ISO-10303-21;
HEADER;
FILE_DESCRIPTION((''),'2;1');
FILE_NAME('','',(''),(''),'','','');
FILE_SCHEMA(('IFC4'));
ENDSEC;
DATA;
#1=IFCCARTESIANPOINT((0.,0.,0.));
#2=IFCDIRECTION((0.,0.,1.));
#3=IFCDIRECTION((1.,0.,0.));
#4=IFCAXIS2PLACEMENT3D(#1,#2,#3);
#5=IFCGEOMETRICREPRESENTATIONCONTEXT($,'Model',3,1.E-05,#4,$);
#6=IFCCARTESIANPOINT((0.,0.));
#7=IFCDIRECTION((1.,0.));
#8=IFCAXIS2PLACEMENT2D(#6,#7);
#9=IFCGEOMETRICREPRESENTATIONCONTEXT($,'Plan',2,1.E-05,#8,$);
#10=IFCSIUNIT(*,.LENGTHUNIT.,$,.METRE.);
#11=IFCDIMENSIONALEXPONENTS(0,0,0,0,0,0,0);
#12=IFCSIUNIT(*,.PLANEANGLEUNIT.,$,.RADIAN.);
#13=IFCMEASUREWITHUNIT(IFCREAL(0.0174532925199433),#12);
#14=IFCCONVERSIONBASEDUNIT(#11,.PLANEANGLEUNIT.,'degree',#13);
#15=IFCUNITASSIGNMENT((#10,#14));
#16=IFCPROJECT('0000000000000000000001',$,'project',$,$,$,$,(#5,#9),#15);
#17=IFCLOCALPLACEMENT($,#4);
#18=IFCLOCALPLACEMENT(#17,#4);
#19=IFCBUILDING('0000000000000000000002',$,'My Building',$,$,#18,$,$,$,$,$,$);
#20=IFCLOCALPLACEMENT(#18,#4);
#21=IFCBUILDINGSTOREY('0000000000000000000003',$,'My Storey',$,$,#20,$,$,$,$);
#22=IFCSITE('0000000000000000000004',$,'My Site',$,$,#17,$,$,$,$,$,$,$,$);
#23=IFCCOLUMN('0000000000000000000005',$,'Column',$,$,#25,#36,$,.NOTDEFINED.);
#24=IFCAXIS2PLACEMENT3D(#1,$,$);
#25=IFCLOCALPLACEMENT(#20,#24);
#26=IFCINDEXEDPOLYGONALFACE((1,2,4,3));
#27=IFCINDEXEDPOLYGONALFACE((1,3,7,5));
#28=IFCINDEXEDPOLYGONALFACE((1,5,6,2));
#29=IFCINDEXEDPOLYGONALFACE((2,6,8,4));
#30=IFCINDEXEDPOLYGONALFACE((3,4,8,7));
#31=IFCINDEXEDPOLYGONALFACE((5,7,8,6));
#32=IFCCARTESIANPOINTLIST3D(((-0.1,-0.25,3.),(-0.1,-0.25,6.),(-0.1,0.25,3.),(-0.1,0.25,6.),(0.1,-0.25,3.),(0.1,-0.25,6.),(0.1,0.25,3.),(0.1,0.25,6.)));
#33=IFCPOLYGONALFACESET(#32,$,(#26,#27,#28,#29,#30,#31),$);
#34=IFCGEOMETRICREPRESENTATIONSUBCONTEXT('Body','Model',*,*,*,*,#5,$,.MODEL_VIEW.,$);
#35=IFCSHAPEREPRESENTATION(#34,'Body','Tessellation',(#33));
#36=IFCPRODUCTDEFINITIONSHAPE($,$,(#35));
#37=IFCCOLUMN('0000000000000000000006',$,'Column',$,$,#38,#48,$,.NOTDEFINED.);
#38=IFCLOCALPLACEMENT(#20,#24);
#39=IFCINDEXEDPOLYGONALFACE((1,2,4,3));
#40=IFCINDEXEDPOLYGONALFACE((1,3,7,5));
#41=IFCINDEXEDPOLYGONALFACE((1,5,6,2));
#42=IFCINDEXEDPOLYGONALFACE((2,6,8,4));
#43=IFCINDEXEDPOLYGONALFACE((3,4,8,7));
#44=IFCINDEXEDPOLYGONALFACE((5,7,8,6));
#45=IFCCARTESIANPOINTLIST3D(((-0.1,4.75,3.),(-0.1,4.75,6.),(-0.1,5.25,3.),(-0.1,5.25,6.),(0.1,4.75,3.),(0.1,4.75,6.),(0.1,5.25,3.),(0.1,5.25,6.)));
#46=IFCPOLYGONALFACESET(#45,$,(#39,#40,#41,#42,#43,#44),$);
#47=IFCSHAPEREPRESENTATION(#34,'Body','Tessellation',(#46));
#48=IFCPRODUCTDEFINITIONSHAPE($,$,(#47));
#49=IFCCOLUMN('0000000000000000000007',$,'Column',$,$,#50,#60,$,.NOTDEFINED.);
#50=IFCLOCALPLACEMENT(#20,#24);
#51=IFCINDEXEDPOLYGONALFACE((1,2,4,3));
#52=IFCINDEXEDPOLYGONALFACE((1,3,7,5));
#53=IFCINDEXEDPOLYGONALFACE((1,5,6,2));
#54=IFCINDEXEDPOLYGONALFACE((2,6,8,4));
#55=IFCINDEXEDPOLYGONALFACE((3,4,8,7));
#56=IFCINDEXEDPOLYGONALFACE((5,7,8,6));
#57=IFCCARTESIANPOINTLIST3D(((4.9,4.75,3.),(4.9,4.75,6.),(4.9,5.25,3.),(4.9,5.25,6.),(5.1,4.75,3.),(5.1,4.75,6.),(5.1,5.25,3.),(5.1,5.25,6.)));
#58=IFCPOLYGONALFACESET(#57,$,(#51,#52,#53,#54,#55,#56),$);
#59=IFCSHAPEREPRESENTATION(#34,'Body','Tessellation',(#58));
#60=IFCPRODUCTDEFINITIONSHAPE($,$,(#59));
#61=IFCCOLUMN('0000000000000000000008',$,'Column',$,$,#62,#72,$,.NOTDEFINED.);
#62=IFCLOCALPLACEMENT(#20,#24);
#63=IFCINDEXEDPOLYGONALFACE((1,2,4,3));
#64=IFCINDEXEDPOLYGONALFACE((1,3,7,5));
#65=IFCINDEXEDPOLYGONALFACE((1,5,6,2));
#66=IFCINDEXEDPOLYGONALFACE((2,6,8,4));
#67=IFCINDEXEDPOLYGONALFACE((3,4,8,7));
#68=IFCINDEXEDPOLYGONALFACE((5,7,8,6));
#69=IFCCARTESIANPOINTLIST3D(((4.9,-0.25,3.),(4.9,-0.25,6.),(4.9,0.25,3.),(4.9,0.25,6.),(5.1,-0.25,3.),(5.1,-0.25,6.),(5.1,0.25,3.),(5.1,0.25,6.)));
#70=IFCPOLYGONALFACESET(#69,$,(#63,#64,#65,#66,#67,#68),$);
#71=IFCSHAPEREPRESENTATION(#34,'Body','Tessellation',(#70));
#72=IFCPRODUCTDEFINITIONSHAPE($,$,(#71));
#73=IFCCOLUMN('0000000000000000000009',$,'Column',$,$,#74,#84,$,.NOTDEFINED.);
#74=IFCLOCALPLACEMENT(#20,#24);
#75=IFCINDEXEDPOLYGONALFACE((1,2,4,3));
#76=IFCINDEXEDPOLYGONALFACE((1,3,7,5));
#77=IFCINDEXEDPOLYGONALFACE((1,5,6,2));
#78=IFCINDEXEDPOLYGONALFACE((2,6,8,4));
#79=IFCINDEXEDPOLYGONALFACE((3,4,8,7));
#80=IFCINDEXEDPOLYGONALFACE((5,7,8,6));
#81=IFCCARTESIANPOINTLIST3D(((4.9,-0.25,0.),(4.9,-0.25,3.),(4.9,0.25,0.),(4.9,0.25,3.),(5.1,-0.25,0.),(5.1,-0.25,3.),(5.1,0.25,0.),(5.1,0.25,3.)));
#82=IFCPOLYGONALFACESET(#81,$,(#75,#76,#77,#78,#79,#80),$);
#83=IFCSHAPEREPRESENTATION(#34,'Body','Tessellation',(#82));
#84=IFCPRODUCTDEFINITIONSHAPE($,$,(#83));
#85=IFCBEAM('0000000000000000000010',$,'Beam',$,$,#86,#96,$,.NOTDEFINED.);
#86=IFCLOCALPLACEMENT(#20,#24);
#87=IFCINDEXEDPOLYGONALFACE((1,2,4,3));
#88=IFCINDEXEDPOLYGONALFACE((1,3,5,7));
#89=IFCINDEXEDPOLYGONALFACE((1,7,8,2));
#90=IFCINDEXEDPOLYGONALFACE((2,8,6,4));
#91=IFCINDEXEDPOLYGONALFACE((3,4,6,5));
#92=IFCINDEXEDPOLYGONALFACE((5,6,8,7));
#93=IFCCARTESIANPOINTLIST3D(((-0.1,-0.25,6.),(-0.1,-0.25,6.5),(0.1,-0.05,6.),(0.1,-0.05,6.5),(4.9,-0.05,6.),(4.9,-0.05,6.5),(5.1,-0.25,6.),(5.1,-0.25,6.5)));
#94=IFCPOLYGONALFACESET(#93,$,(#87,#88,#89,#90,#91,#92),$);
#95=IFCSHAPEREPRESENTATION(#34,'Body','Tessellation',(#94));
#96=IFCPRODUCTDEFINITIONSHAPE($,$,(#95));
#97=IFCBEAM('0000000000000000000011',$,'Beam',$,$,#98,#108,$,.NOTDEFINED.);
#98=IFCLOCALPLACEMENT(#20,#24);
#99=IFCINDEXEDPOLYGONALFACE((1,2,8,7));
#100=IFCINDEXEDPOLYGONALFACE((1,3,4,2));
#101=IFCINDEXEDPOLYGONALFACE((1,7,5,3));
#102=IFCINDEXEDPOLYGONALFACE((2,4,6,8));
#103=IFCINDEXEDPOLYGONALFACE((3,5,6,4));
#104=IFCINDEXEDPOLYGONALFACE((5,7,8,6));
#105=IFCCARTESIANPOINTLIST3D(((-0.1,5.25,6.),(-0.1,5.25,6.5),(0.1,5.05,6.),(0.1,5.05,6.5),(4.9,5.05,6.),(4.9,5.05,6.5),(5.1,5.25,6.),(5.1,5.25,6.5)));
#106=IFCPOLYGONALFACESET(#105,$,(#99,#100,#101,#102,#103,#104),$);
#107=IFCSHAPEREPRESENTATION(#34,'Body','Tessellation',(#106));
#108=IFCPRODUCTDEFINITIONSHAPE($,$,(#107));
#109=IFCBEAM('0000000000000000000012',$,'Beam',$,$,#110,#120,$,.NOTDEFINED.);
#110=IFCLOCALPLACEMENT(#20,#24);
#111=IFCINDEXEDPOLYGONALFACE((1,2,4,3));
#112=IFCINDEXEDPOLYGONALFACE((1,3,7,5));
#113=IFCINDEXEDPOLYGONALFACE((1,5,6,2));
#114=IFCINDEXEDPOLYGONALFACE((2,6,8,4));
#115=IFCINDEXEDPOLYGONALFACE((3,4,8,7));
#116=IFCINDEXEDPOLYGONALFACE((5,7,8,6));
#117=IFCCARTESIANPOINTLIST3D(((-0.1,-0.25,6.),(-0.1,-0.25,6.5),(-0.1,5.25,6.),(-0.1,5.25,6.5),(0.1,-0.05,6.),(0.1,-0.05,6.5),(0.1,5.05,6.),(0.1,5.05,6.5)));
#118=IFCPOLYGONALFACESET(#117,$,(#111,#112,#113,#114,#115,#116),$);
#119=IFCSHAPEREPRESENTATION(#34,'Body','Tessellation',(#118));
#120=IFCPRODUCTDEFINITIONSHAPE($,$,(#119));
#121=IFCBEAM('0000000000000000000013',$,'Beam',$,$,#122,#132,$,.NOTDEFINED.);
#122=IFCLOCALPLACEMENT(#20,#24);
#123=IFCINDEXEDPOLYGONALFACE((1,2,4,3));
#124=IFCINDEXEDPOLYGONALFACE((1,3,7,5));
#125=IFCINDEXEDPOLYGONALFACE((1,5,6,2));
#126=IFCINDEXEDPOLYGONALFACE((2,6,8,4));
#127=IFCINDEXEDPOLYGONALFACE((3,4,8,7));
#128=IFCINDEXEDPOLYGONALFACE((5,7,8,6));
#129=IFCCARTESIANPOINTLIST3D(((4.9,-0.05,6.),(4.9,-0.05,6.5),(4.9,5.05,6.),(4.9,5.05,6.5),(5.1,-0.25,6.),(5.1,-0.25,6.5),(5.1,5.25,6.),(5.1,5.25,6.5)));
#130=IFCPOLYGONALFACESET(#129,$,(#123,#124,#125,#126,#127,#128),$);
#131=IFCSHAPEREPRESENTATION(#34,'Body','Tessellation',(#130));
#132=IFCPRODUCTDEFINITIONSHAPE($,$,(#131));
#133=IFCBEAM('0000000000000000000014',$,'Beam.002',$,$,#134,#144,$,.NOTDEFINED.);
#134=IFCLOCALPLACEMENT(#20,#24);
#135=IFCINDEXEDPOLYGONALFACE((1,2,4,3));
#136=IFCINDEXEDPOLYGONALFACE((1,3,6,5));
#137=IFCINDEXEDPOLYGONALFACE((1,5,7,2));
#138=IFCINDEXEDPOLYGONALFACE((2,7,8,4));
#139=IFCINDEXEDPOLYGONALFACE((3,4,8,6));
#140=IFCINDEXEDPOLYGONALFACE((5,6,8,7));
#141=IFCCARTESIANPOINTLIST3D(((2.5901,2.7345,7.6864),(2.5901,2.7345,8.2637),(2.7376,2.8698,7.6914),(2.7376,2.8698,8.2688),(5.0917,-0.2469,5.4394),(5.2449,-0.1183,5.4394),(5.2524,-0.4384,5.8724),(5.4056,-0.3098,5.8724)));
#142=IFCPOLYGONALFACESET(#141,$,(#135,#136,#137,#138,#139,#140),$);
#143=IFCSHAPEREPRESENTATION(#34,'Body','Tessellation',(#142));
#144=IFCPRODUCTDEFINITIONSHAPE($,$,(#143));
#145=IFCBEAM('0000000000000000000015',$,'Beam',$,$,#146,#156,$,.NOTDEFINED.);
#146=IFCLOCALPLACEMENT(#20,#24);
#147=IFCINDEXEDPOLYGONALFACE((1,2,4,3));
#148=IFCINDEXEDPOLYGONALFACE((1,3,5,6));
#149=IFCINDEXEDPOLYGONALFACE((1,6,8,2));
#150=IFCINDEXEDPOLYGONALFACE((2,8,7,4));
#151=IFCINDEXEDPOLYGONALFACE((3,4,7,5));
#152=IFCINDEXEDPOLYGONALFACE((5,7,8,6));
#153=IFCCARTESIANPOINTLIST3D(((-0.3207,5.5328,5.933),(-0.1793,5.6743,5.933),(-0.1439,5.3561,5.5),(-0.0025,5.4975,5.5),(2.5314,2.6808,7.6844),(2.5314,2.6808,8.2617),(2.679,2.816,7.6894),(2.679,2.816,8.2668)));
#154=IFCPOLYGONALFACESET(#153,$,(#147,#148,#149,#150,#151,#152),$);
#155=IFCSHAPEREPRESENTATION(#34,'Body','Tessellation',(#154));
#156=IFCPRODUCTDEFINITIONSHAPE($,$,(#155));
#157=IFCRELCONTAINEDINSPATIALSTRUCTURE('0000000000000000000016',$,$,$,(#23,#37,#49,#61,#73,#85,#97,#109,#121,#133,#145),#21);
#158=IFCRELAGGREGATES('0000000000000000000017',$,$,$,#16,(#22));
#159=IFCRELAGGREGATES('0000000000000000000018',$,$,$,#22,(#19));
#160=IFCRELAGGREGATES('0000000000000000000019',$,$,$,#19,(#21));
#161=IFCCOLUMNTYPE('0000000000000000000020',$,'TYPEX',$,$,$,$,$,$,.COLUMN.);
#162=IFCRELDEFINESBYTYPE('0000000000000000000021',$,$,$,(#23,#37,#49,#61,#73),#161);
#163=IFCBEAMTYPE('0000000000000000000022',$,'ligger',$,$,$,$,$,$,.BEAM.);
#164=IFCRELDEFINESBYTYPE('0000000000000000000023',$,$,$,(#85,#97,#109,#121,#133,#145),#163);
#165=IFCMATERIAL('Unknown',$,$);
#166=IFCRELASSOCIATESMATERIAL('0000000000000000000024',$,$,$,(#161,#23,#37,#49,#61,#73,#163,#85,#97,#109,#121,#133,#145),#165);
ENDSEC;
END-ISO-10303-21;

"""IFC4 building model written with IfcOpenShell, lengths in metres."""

from ifc_helpers import new_model, entity, si_unit, converted_unit, frame, origin_with_axes, origin_2d_with_axis, place, context, subcontext, project, spatial, rectangle, extrude, clip, halfspace, material, material_profile, profile_set, profile_usage, type_object, element, save


model = new_model("IFC4")

# Units and contexts
model_context = context("Model", 3, precision=1e-05, world=origin_with_axes())
plan_context = context("Plan", 2, precision=1e-05, world=origin_2d_with_axis())
body_context = subcontext(model_context, "Body", "Model", "MODEL_VIEW")
ifc_project = project(units=[si_unit("LENGTHUNIT", "METRE"), converted_unit("PLANEANGLEUNIT", "degree", entity("IfcReal", 0.0174532925199433), si_unit("PLANEANGLEUNIT", "RADIAN"), dimensions=[0, 0, 0, 0, 0, 0, 0])], contexts=[model_context, plan_context])

# Site, building, storey
site_placement = place(None, origin_with_axes())
site = spatial("IfcSite", under=ifc_project, at=site_placement, Name="My Site")
building_placement = place(site_placement, origin_with_axes())
building = spatial("IfcBuilding", under=site, at=building_placement, Name="My Building")
storey_placement = place(building_placement, origin_with_axes())
storey = spatial("IfcBuildingStorey", under=building, at=storey_placement, Name="My Storey")

# Columns
ifc_material = material(Name="Unknown")
ifc_material_profile_1 = material_profile(ifc_material, rectangle(XDim=0.2, YDim=0.5))
ifc_profile_set_1 = profile_set([ifc_material_profile_1])
ifc_profile_usage_1 = profile_usage(ifc_profile_set_1, cardinal=5)
column_type = type_object("IfcColumnType", Name="TYPEX", PredefinedType="COLUMN", material=ifc_profile_set_1)
column_1_placement = place(storey_placement, frame((0.0, 0.0, 3.0), z_axis=(0.0, 0.0, 1.0), x_axis=(1.0, 0.0, 0.0)))
element("IfcColumn", 1, at=column_1_placement, inside=storey, type_object=column_type, material=ifc_profile_usage_1, Name="Column", PredefinedType="NOTDEFINED", context=body_context, shape_type="SweptSolid", body=[
    extrude(rectangle(XDim=0.2, YDim=0.5), origin_with_axes(), (0.0, 0.0, 1.0), 3.0),
])
ifc_profile_usage_2 = profile_usage(ifc_profile_set_1, cardinal=5)
column_2_placement = place(storey_placement, frame((0.0, 5.0, 3.0), z_axis=(0.0, 0.0, 1.0), x_axis=(1.0, 0.0, 0.0)))
element("IfcColumn", 2, at=column_2_placement, inside=storey, type_object=column_type, material=ifc_profile_usage_2, Name="Column", PredefinedType="NOTDEFINED", context=body_context, shape_type="SweptSolid", body=[
    extrude(rectangle(XDim=0.2, YDim=0.5), origin_with_axes(), (0.0, 0.0, 1.0), 3.0),
])
ifc_profile_usage_3 = profile_usage(ifc_profile_set_1, cardinal=5)
column_3_placement = place(storey_placement, frame((5.0, 5.0, 3.0), z_axis=(0.0, 0.0, 1.0), x_axis=(1.0, 0.0, 0.0)))
element("IfcColumn", 3, at=column_3_placement, inside=storey, type_object=column_type, material=ifc_profile_usage_3, Name="Column", PredefinedType="NOTDEFINED", context=body_context, shape_type="SweptSolid", body=[
    extrude(rectangle(XDim=0.2, YDim=0.5), origin_with_axes(), (0.0, 0.0, 1.0), 3.0),
])
ifc_profile_usage_4 = profile_usage(ifc_profile_set_1, cardinal=5)
column_4_placement = place(storey_placement, frame((5.0, 0.0, 3.0), z_axis=(0.0, 0.0, 1.0), x_axis=(1.0, 0.0, 0.0)))
element("IfcColumn", 4, at=column_4_placement, inside=storey, type_object=column_type, material=ifc_profile_usage_4, Name="Column", PredefinedType="NOTDEFINED", context=body_context, shape_type="SweptSolid", body=[
    extrude(rectangle(XDim=0.2, YDim=0.5), origin_with_axes(), (0.0, 0.0, 1.0), 3.0),
])
ifc_profile_usage_5 = profile_usage(ifc_profile_set_1, cardinal=5)
column_5_placement = place(storey_placement, frame((5.0, 0.0, 0.0), z_axis=(0.0, 0.0, 1.0), x_axis=(1.0, 0.0, 0.0)))
element("IfcColumn", 5, at=column_5_placement, inside=storey, type_object=column_type, material=ifc_profile_usage_5, Name="Column", PredefinedType="NOTDEFINED", context=body_context, shape_type="SweptSolid", body=[
    extrude(rectangle(XDim=0.2, YDim=0.5), origin_with_axes(), (0.0, 0.0, 1.0), 3.0),
])

# Beams
ifc_material_profile_2 = material_profile(ifc_material, rectangle(XDim=0.2, YDim=0.5))
ifc_material_profile_3 = material_profile(ifc_material, rectangle(XDim=0.2, YDim=0.4))
ifc_profile_set_2 = profile_set([ifc_material_profile_2, ifc_material_profile_3])
ifc_profile_usage_6 = profile_usage(ifc_profile_set_2, cardinal=5)
beam_type = type_object("IfcBeamType", Name="ligger", PredefinedType="BEAM", material=ifc_profile_set_2)
beam_1_placement = place(storey_placement, frame((-0.1, -0.15, 6.25), z_axis=(1.0, 0.0, 0.0), x_axis=(0.0, 1.0, 0.0)))
element("IfcBeam", 6, at=beam_1_placement, inside=storey, type_object=beam_type, material=ifc_profile_usage_6, Name="Beam", PredefinedType="NOTDEFINED", context=body_context, shape_type="Clipping", body=[
    clip(clip(extrude(rectangle(XDim=0.2, YDim=0.5), origin_with_axes(), (0.0, 0.0, 1.0), 5.2), halfspace(frame((-0.1, -5.25, 0.0), z_axis=(0.707107, 0.0, -0.707107), x_axis=(0.707107, 0.0, 0.707107)), False)), halfspace(frame((-0.1, -5.25, 5.2), z_axis=(0.707106, 0.0, 0.707107), x_axis=(0.707107, 0.0, -0.707106)), False)),
])
ifc_profile_usage_7 = profile_usage(ifc_profile_set_2, cardinal=5)
beam_2_placement = place(storey_placement, frame((-0.1, 5.15, 6.25), z_axis=(1.0, 0.0, 0.0), x_axis=(0.0, 1.0, 0.0)))
element("IfcBeam", 7, at=beam_2_placement, inside=storey, type_object=beam_type, material=ifc_profile_usage_7, Name="Beam", PredefinedType="NOTDEFINED", context=body_context, shape_type="Clipping", body=[
    clip(clip(extrude(rectangle(XDim=0.2, YDim=0.5), origin_with_axes(), (0.0, 0.0, 1.0), 5.2), halfspace(frame((0.1, -5.25, 0.0), z_axis=(-0.707107, 0.0, -0.707107), x_axis=(-0.707107, 0.0, 0.707107)), False)), halfspace(frame((0.1, -5.25, 5.2), z_axis=(-0.707107, 0.0, 0.707107), x_axis=(-0.707107, 0.0, -0.707107)), False)),
])
ifc_profile_usage_8 = profile_usage(ifc_profile_set_2, cardinal=5)
beam_3_placement = place(storey_placement, frame((0.0, 5.25, 6.25), z_axis=(0.0, -1.0, 0.0), x_axis=(1.0, 0.0, 0.0)))
element("IfcBeam", 8, at=beam_3_placement, inside=storey, type_object=beam_type, material=ifc_profile_usage_8, Name="Beam", PredefinedType="NOTDEFINED", context=body_context, shape_type="Clipping", body=[
    clip(clip(extrude(rectangle(XDim=0.2, YDim=0.5), origin_with_axes(), (0.0, 0.0, 1.0), 5.5), halfspace(frame((-0.1, -5.25, 0.0), z_axis=(0.707106, 0.0, -0.707107), x_axis=(0.707107, 0.0, 0.707106)), False)), halfspace(frame((-0.1, -5.25, 5.5), z_axis=(0.707107, 0.0, 0.707107), x_axis=(0.707107, 0.0, -0.707107)), False)),
])
ifc_profile_usage_9 = profile_usage(ifc_profile_set_2, cardinal=5)
beam_4_placement = place(storey_placement, frame((5.0, -0.25, 6.25), z_axis=(0.0, 1.0, 0.0), x_axis=(-1.0, 0.0, 0.0)))
element("IfcBeam", 9, at=beam_4_placement, inside=storey, type_object=beam_type, material=ifc_profile_usage_9, Name="Beam", PredefinedType="NOTDEFINED", context=body_context, shape_type="Clipping", body=[
    clip(clip(extrude(rectangle(XDim=0.2, YDim=0.5), origin_with_axes(), (0.0, 0.0, 1.0), 5.5), halfspace(frame((-0.1, -5.25, 5.5), z_axis=(0.707107, 0.0, 0.707107), x_axis=(0.707107, 0.0, -0.707107)), False)), halfspace(frame((-0.1, -5.25, 0.0), z_axis=(0.707107, 0.0, -0.707107), x_axis=(0.707107, 0.0, 0.707107)), False)),
])
ifc_profile_usage_10 = profile_usage(ifc_profile_set_2, cardinal=5)
beam_5_placement = place(storey_placement, frame((5.2487, -0.2783, 5.6559), z_axis=(-0.556671, 0.663414, 0.5), x_axis=(-0.766044, -0.642788, 0.0)))
element("IfcBeam", 10, at=beam_5_placement, inside=storey, type_object=beam_type, material=ifc_profile_usage_10, Name="Beam.002", PredefinedType="NOTDEFINED", context=body_context, shape_type="Clipping", body=[
    clip(extrude(rectangle(XDim=0.2, YDim=0.5), origin_with_axes(), (0.0, 0.0, 1.0), 5.4326), halfspace(frame((4.0588, 0.25, 4.5831), z_axis=(0.04362, -0.499523, 0.865202), x_axis=(-0.025152, -0.866301, -0.498889)), False)),
])
ifc_profile_usage_11 = profile_usage(ifc_profile_set_2, cardinal=5)
beam_6_placement = place(storey_placement, frame((-0.1616, 5.5152, 5.7165), z_axis=(0.612372, -0.612372, 0.5), x_axis=(0.707107, 0.707107, 0.0)))
element("IfcBeam", 11, at=beam_6_placement, inside=storey, type_object=beam_type, material=ifc_profile_usage_11, Name="Beam", PredefinedType="NOTDEFINED", context=body_context, shape_type="Clipping", body=[
    clip(extrude(rectangle(XDim=0.2, YDim=0.5), origin_with_axes(), (0.0, 0.0, 1.0), 5.3074), halfspace(frame((-3.9793, 0.25, 4.4619), z_axis=(-0.043619, -0.499525, 0.8652), x_axis=(0.025152, -0.866299, -0.498892)), False)),
])

save(model, "model.ifc")
